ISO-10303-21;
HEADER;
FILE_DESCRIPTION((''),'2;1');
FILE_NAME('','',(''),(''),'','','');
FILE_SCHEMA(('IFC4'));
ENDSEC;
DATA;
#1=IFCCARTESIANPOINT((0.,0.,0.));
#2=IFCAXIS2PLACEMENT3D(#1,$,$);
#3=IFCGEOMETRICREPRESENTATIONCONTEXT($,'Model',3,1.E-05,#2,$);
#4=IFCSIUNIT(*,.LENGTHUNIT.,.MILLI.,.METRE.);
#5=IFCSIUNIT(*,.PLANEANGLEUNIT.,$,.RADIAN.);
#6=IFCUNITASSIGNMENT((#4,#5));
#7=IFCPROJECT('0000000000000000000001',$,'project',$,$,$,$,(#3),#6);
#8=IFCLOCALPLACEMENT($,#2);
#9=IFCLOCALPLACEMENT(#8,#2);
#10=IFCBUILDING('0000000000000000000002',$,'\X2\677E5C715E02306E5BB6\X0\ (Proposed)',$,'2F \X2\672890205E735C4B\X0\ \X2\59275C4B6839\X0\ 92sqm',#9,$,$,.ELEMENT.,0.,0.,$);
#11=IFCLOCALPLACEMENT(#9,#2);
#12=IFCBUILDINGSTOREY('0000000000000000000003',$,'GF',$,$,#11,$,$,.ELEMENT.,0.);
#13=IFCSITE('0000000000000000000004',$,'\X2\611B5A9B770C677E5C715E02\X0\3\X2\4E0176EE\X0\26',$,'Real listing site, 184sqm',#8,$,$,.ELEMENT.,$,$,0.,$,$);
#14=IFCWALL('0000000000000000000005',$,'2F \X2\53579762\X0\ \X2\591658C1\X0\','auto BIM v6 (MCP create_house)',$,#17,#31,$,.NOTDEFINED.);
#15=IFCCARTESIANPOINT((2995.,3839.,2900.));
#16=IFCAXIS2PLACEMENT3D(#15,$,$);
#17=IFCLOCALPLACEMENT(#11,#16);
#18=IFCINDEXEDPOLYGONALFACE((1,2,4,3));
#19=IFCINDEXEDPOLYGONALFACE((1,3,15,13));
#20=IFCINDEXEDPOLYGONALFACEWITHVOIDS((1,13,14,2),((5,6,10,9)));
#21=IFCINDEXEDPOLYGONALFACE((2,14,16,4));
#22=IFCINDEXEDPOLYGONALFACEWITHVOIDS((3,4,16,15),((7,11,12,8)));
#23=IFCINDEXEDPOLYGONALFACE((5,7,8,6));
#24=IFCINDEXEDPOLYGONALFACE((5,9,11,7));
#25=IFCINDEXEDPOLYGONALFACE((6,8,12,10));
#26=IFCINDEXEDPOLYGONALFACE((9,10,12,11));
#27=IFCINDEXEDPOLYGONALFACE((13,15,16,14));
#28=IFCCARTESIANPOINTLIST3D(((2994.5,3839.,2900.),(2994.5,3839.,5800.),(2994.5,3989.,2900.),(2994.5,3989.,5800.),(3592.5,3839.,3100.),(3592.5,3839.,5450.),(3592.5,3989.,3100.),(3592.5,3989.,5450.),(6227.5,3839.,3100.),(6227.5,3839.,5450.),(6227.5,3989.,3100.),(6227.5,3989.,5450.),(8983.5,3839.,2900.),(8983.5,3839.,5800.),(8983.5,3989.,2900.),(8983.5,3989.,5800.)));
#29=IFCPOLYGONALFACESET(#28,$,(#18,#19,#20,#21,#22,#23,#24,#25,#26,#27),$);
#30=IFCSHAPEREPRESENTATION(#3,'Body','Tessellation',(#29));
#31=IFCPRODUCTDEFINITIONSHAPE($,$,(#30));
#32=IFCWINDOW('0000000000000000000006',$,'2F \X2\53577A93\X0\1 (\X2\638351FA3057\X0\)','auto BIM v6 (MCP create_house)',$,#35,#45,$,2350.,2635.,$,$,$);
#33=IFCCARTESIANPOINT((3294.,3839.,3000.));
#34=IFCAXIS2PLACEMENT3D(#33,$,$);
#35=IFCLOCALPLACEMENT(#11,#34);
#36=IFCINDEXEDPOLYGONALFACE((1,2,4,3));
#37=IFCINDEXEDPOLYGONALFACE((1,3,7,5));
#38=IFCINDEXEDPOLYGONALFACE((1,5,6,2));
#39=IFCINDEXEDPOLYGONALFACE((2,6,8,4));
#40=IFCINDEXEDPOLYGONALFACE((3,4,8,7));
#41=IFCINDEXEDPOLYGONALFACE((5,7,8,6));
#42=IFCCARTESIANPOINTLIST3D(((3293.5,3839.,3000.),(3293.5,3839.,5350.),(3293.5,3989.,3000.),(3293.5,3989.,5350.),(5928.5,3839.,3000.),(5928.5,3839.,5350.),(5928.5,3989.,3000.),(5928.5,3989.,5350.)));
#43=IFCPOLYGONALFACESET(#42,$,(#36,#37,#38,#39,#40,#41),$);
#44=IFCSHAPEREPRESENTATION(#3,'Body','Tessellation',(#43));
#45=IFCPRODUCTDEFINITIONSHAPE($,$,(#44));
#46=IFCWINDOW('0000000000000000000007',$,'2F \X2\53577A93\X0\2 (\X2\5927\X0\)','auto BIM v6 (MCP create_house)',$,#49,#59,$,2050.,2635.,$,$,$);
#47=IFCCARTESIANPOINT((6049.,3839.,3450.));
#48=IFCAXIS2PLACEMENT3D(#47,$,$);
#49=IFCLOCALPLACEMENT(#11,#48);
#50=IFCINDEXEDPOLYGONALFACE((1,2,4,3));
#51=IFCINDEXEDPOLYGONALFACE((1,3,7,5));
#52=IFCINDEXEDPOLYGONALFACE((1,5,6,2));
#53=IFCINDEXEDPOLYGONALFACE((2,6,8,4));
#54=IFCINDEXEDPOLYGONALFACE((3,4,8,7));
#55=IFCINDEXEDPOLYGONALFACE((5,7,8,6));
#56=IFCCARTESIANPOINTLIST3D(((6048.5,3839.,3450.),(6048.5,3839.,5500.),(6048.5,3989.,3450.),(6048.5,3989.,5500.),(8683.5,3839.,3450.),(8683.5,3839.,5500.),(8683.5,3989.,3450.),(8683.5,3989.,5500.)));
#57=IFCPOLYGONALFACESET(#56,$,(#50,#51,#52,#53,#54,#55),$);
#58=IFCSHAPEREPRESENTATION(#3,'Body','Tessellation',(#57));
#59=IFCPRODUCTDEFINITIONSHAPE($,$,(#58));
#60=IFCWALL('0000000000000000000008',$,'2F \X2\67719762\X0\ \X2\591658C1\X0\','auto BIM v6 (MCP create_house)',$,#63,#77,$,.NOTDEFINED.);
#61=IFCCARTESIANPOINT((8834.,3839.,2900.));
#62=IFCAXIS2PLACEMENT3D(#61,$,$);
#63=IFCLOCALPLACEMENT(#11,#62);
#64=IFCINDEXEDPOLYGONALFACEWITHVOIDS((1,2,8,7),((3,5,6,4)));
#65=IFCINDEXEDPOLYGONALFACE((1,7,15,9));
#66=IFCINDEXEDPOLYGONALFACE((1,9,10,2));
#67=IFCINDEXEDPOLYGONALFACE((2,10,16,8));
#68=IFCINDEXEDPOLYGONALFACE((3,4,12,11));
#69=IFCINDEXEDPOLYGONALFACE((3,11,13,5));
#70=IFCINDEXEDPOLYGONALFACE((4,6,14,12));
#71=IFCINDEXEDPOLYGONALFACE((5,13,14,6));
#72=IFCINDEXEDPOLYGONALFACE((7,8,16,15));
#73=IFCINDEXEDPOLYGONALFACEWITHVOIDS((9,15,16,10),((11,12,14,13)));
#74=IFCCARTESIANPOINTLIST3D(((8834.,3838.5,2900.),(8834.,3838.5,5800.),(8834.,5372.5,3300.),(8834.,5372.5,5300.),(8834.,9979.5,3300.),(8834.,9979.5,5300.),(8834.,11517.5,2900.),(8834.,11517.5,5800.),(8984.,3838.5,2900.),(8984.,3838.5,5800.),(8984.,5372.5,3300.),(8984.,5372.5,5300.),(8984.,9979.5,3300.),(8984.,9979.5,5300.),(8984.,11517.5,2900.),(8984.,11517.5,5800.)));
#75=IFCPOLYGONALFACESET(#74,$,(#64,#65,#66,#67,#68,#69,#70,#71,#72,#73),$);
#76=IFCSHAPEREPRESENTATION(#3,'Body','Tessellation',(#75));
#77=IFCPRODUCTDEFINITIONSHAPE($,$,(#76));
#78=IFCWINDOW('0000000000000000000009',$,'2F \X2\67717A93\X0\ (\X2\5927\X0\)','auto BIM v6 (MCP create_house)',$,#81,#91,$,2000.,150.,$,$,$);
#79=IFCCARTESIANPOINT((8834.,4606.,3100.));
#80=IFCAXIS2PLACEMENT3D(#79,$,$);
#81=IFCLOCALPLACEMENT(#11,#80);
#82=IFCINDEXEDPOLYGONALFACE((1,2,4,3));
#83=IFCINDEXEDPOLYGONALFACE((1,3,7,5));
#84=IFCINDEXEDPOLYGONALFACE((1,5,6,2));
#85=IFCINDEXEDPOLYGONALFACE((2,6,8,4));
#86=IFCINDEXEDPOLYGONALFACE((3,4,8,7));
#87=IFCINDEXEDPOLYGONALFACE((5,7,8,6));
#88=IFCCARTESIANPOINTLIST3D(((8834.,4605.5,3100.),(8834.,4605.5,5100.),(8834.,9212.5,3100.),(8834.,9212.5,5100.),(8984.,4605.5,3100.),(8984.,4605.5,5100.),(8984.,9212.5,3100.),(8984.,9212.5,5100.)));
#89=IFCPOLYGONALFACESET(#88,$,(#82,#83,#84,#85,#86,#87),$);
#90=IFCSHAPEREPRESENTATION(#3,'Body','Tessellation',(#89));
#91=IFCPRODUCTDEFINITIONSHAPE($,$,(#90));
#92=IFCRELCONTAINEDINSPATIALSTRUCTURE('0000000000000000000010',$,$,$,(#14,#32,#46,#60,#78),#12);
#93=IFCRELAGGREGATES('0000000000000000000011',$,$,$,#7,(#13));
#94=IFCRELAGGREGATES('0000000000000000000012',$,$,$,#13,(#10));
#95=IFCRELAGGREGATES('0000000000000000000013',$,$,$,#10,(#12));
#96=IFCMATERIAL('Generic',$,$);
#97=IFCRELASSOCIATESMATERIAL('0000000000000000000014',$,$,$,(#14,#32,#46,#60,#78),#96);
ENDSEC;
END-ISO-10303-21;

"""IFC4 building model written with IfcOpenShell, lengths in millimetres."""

from ifc_helpers import new_model, si_unit, frame, frame_2d, origin, place, context, project, spatial, rectangle, extrude, material, element, fill, save


model = new_model("IFC4")

# Units and contexts
model_context = context("Model", 3, precision=1e-05, world=origin())
ifc_project = project(units=[si_unit("LENGTHUNIT", "METRE", prefix="MILLI"), si_unit("PLANEANGLEUNIT", "RADIAN")], contexts=[model_context])

# Site, building, storey
site_placement = place(None, origin())
site = spatial("IfcSite", under=ifc_project, at=site_placement, Name="愛媛県松山市3丁目26", ObjectType="Real listing site, 184sqm", CompositionType="ELEMENT", RefElevation=0.0)
building_placement = place(site_placement, origin())
building = spatial("IfcBuilding", under=site, at=building_placement, Name="松山市の家 (Proposed)", ObjectType="2F 木造平屋 大屋根 92sqm", CompositionType="ELEMENT", ElevationOfRefHeight=0.0, ElevationOfTerrain=0.0)
storey_placement = place(building_placement, origin())
storey = spatial("IfcBuildingStorey", under=building, at=storey_placement, Name="GF", CompositionType="ELEMENT", Elevation=0.0)

# Shared definitions
ifc_material = material(Name="Generic")

# Wall, openings, windows
wall_1_placement = place(storey_placement, frame((2995.0, 3839.0, 2900.0)))
wall_1 = element("IfcWall", 1, at=wall_1_placement, inside=storey, material=ifc_material, Name="2F 南面 外壁", Description="auto BIM v6 (MCP create_house)", PredefinedType="NOTDEFINED", context=model_context, shape_type="SweptSolid", body=[
    extrude(rectangle(XDim=5989.0, YDim=150.0, at=frame_2d((2994.0, 75.0))), frame((2995.0, 3839.0, 2900.0)), (0.0, 0.0, 1.0), 2900.0),
])
opening_1_placement = place(storey_placement, frame((3294.0, 3839.0, 3000.0)))
opening_1 = element("IfcOpeningElement", 2, at=opening_1_placement, cuts=wall_1, PredefinedType="NOTDEFINED", context=model_context, shape_type="SweptSolid", body=[
    extrude(rectangle(XDim=2635.0, YDim=150.0, at=frame_2d((1317.0, 75.0))), frame((3294.0, 3839.0, 3000.0)), (0.0, 0.0, 1.0), 2350.0),
])
opening_2_placement = place(storey_placement, frame((6049.0, 3839.0, 3450.0)))
opening_2 = element("IfcOpeningElement", 3, at=opening_2_placement, cuts=wall_1, PredefinedType="NOTDEFINED", context=model_context, shape_type="SweptSolid", body=[
    extrude(rectangle(XDim=2635.0, YDim=150.0, at=frame_2d((1317.0, 75.0))), frame((6049.0, 3839.0, 3450.0)), (0.0, 0.0, 1.0), 2050.0),
])
window_1_placement = place(storey_placement, frame((3294.0, 3839.0, 3000.0)))
window_1 = element("IfcWindow", 4, at=window_1_placement, inside=storey, material=ifc_material, Name="2F 南窓1 (掃出し)", Description="auto BIM v6 (MCP create_house)", OverallHeight=2350.0, OverallWidth=2635.0, context=model_context, shape_type="SweptSolid", body=[
    extrude(rectangle(XDim=2635.0, YDim=150.0, at=frame_2d((1317.0, 75.0))), frame((3294.0, 3839.0, 3000.0)), (0.0, 0.0, 1.0), 2350.0),
])
fill(opening_1, window_1)
window_2_placement = place(storey_placement, frame((6049.0, 3839.0, 3450.0)))
window_2 = element("IfcWindow", 5, at=window_2_placement, inside=storey, material=ifc_material, Name="2F 南窓2 (大)", Description="auto BIM v6 (MCP create_house)", OverallHeight=2050.0, OverallWidth=2635.0, context=model_context, shape_type="SweptSolid", body=[
    extrude(rectangle(XDim=2635.0, YDim=150.0, at=frame_2d((1317.0, 75.0))), frame((6049.0, 3839.0, 3450.0)), (0.0, 0.0, 1.0), 2050.0),
])
fill(opening_2, window_2)

# Wall, opening, window
wall_2_placement = place(storey_placement, frame((8834.0, 3839.0, 2900.0)))
wall_2 = element("IfcWall", 6, at=wall_2_placement, inside=storey, material=ifc_material, Name="2F 東面 外壁", Description="auto BIM v6 (MCP create_house)", PredefinedType="NOTDEFINED", context=model_context, shape_type="SweptSolid", body=[
    extrude(rectangle(XDim=150.0, YDim=7679.0, at=frame_2d((75.0, 3839.0))), frame((8834.0, 3839.0, 2900.0)), (0.0, 0.0, 1.0), 2900.0),
])
opening_3_placement = place(storey_placement, frame((8834.0, 4606.0, 3100.0)))
opening_3 = element("IfcOpeningElement", 7, at=opening_3_placement, cuts=wall_2, PredefinedType="NOTDEFINED", context=model_context, shape_type="SweptSolid", body=[
    extrude(rectangle(XDim=150.0, YDim=4607.0, at=frame_2d((75.0, 2303.0))), frame((8834.0, 4606.0, 3100.0)), (0.0, 0.0, 1.0), 2000.0),
])
window_3_placement = place(storey_placement, frame((8834.0, 4606.0, 3100.0)))
window_3 = element("IfcWindow", 8, at=window_3_placement, inside=storey, material=ifc_material, Name="2F 東窓 (大)", Description="auto BIM v6 (MCP create_house)", OverallHeight=2000.0, OverallWidth=150.0, context=model_context, shape_type="SweptSolid", body=[
    extrude(rectangle(XDim=150.0, YDim=4607.0, at=frame_2d((75.0, 2303.0))), frame((8834.0, 4606.0, 3100.0)), (0.0, 0.0, 1.0), 2000.0),
])
fill(opening_3, window_3)

save(model, "model.ifc")
